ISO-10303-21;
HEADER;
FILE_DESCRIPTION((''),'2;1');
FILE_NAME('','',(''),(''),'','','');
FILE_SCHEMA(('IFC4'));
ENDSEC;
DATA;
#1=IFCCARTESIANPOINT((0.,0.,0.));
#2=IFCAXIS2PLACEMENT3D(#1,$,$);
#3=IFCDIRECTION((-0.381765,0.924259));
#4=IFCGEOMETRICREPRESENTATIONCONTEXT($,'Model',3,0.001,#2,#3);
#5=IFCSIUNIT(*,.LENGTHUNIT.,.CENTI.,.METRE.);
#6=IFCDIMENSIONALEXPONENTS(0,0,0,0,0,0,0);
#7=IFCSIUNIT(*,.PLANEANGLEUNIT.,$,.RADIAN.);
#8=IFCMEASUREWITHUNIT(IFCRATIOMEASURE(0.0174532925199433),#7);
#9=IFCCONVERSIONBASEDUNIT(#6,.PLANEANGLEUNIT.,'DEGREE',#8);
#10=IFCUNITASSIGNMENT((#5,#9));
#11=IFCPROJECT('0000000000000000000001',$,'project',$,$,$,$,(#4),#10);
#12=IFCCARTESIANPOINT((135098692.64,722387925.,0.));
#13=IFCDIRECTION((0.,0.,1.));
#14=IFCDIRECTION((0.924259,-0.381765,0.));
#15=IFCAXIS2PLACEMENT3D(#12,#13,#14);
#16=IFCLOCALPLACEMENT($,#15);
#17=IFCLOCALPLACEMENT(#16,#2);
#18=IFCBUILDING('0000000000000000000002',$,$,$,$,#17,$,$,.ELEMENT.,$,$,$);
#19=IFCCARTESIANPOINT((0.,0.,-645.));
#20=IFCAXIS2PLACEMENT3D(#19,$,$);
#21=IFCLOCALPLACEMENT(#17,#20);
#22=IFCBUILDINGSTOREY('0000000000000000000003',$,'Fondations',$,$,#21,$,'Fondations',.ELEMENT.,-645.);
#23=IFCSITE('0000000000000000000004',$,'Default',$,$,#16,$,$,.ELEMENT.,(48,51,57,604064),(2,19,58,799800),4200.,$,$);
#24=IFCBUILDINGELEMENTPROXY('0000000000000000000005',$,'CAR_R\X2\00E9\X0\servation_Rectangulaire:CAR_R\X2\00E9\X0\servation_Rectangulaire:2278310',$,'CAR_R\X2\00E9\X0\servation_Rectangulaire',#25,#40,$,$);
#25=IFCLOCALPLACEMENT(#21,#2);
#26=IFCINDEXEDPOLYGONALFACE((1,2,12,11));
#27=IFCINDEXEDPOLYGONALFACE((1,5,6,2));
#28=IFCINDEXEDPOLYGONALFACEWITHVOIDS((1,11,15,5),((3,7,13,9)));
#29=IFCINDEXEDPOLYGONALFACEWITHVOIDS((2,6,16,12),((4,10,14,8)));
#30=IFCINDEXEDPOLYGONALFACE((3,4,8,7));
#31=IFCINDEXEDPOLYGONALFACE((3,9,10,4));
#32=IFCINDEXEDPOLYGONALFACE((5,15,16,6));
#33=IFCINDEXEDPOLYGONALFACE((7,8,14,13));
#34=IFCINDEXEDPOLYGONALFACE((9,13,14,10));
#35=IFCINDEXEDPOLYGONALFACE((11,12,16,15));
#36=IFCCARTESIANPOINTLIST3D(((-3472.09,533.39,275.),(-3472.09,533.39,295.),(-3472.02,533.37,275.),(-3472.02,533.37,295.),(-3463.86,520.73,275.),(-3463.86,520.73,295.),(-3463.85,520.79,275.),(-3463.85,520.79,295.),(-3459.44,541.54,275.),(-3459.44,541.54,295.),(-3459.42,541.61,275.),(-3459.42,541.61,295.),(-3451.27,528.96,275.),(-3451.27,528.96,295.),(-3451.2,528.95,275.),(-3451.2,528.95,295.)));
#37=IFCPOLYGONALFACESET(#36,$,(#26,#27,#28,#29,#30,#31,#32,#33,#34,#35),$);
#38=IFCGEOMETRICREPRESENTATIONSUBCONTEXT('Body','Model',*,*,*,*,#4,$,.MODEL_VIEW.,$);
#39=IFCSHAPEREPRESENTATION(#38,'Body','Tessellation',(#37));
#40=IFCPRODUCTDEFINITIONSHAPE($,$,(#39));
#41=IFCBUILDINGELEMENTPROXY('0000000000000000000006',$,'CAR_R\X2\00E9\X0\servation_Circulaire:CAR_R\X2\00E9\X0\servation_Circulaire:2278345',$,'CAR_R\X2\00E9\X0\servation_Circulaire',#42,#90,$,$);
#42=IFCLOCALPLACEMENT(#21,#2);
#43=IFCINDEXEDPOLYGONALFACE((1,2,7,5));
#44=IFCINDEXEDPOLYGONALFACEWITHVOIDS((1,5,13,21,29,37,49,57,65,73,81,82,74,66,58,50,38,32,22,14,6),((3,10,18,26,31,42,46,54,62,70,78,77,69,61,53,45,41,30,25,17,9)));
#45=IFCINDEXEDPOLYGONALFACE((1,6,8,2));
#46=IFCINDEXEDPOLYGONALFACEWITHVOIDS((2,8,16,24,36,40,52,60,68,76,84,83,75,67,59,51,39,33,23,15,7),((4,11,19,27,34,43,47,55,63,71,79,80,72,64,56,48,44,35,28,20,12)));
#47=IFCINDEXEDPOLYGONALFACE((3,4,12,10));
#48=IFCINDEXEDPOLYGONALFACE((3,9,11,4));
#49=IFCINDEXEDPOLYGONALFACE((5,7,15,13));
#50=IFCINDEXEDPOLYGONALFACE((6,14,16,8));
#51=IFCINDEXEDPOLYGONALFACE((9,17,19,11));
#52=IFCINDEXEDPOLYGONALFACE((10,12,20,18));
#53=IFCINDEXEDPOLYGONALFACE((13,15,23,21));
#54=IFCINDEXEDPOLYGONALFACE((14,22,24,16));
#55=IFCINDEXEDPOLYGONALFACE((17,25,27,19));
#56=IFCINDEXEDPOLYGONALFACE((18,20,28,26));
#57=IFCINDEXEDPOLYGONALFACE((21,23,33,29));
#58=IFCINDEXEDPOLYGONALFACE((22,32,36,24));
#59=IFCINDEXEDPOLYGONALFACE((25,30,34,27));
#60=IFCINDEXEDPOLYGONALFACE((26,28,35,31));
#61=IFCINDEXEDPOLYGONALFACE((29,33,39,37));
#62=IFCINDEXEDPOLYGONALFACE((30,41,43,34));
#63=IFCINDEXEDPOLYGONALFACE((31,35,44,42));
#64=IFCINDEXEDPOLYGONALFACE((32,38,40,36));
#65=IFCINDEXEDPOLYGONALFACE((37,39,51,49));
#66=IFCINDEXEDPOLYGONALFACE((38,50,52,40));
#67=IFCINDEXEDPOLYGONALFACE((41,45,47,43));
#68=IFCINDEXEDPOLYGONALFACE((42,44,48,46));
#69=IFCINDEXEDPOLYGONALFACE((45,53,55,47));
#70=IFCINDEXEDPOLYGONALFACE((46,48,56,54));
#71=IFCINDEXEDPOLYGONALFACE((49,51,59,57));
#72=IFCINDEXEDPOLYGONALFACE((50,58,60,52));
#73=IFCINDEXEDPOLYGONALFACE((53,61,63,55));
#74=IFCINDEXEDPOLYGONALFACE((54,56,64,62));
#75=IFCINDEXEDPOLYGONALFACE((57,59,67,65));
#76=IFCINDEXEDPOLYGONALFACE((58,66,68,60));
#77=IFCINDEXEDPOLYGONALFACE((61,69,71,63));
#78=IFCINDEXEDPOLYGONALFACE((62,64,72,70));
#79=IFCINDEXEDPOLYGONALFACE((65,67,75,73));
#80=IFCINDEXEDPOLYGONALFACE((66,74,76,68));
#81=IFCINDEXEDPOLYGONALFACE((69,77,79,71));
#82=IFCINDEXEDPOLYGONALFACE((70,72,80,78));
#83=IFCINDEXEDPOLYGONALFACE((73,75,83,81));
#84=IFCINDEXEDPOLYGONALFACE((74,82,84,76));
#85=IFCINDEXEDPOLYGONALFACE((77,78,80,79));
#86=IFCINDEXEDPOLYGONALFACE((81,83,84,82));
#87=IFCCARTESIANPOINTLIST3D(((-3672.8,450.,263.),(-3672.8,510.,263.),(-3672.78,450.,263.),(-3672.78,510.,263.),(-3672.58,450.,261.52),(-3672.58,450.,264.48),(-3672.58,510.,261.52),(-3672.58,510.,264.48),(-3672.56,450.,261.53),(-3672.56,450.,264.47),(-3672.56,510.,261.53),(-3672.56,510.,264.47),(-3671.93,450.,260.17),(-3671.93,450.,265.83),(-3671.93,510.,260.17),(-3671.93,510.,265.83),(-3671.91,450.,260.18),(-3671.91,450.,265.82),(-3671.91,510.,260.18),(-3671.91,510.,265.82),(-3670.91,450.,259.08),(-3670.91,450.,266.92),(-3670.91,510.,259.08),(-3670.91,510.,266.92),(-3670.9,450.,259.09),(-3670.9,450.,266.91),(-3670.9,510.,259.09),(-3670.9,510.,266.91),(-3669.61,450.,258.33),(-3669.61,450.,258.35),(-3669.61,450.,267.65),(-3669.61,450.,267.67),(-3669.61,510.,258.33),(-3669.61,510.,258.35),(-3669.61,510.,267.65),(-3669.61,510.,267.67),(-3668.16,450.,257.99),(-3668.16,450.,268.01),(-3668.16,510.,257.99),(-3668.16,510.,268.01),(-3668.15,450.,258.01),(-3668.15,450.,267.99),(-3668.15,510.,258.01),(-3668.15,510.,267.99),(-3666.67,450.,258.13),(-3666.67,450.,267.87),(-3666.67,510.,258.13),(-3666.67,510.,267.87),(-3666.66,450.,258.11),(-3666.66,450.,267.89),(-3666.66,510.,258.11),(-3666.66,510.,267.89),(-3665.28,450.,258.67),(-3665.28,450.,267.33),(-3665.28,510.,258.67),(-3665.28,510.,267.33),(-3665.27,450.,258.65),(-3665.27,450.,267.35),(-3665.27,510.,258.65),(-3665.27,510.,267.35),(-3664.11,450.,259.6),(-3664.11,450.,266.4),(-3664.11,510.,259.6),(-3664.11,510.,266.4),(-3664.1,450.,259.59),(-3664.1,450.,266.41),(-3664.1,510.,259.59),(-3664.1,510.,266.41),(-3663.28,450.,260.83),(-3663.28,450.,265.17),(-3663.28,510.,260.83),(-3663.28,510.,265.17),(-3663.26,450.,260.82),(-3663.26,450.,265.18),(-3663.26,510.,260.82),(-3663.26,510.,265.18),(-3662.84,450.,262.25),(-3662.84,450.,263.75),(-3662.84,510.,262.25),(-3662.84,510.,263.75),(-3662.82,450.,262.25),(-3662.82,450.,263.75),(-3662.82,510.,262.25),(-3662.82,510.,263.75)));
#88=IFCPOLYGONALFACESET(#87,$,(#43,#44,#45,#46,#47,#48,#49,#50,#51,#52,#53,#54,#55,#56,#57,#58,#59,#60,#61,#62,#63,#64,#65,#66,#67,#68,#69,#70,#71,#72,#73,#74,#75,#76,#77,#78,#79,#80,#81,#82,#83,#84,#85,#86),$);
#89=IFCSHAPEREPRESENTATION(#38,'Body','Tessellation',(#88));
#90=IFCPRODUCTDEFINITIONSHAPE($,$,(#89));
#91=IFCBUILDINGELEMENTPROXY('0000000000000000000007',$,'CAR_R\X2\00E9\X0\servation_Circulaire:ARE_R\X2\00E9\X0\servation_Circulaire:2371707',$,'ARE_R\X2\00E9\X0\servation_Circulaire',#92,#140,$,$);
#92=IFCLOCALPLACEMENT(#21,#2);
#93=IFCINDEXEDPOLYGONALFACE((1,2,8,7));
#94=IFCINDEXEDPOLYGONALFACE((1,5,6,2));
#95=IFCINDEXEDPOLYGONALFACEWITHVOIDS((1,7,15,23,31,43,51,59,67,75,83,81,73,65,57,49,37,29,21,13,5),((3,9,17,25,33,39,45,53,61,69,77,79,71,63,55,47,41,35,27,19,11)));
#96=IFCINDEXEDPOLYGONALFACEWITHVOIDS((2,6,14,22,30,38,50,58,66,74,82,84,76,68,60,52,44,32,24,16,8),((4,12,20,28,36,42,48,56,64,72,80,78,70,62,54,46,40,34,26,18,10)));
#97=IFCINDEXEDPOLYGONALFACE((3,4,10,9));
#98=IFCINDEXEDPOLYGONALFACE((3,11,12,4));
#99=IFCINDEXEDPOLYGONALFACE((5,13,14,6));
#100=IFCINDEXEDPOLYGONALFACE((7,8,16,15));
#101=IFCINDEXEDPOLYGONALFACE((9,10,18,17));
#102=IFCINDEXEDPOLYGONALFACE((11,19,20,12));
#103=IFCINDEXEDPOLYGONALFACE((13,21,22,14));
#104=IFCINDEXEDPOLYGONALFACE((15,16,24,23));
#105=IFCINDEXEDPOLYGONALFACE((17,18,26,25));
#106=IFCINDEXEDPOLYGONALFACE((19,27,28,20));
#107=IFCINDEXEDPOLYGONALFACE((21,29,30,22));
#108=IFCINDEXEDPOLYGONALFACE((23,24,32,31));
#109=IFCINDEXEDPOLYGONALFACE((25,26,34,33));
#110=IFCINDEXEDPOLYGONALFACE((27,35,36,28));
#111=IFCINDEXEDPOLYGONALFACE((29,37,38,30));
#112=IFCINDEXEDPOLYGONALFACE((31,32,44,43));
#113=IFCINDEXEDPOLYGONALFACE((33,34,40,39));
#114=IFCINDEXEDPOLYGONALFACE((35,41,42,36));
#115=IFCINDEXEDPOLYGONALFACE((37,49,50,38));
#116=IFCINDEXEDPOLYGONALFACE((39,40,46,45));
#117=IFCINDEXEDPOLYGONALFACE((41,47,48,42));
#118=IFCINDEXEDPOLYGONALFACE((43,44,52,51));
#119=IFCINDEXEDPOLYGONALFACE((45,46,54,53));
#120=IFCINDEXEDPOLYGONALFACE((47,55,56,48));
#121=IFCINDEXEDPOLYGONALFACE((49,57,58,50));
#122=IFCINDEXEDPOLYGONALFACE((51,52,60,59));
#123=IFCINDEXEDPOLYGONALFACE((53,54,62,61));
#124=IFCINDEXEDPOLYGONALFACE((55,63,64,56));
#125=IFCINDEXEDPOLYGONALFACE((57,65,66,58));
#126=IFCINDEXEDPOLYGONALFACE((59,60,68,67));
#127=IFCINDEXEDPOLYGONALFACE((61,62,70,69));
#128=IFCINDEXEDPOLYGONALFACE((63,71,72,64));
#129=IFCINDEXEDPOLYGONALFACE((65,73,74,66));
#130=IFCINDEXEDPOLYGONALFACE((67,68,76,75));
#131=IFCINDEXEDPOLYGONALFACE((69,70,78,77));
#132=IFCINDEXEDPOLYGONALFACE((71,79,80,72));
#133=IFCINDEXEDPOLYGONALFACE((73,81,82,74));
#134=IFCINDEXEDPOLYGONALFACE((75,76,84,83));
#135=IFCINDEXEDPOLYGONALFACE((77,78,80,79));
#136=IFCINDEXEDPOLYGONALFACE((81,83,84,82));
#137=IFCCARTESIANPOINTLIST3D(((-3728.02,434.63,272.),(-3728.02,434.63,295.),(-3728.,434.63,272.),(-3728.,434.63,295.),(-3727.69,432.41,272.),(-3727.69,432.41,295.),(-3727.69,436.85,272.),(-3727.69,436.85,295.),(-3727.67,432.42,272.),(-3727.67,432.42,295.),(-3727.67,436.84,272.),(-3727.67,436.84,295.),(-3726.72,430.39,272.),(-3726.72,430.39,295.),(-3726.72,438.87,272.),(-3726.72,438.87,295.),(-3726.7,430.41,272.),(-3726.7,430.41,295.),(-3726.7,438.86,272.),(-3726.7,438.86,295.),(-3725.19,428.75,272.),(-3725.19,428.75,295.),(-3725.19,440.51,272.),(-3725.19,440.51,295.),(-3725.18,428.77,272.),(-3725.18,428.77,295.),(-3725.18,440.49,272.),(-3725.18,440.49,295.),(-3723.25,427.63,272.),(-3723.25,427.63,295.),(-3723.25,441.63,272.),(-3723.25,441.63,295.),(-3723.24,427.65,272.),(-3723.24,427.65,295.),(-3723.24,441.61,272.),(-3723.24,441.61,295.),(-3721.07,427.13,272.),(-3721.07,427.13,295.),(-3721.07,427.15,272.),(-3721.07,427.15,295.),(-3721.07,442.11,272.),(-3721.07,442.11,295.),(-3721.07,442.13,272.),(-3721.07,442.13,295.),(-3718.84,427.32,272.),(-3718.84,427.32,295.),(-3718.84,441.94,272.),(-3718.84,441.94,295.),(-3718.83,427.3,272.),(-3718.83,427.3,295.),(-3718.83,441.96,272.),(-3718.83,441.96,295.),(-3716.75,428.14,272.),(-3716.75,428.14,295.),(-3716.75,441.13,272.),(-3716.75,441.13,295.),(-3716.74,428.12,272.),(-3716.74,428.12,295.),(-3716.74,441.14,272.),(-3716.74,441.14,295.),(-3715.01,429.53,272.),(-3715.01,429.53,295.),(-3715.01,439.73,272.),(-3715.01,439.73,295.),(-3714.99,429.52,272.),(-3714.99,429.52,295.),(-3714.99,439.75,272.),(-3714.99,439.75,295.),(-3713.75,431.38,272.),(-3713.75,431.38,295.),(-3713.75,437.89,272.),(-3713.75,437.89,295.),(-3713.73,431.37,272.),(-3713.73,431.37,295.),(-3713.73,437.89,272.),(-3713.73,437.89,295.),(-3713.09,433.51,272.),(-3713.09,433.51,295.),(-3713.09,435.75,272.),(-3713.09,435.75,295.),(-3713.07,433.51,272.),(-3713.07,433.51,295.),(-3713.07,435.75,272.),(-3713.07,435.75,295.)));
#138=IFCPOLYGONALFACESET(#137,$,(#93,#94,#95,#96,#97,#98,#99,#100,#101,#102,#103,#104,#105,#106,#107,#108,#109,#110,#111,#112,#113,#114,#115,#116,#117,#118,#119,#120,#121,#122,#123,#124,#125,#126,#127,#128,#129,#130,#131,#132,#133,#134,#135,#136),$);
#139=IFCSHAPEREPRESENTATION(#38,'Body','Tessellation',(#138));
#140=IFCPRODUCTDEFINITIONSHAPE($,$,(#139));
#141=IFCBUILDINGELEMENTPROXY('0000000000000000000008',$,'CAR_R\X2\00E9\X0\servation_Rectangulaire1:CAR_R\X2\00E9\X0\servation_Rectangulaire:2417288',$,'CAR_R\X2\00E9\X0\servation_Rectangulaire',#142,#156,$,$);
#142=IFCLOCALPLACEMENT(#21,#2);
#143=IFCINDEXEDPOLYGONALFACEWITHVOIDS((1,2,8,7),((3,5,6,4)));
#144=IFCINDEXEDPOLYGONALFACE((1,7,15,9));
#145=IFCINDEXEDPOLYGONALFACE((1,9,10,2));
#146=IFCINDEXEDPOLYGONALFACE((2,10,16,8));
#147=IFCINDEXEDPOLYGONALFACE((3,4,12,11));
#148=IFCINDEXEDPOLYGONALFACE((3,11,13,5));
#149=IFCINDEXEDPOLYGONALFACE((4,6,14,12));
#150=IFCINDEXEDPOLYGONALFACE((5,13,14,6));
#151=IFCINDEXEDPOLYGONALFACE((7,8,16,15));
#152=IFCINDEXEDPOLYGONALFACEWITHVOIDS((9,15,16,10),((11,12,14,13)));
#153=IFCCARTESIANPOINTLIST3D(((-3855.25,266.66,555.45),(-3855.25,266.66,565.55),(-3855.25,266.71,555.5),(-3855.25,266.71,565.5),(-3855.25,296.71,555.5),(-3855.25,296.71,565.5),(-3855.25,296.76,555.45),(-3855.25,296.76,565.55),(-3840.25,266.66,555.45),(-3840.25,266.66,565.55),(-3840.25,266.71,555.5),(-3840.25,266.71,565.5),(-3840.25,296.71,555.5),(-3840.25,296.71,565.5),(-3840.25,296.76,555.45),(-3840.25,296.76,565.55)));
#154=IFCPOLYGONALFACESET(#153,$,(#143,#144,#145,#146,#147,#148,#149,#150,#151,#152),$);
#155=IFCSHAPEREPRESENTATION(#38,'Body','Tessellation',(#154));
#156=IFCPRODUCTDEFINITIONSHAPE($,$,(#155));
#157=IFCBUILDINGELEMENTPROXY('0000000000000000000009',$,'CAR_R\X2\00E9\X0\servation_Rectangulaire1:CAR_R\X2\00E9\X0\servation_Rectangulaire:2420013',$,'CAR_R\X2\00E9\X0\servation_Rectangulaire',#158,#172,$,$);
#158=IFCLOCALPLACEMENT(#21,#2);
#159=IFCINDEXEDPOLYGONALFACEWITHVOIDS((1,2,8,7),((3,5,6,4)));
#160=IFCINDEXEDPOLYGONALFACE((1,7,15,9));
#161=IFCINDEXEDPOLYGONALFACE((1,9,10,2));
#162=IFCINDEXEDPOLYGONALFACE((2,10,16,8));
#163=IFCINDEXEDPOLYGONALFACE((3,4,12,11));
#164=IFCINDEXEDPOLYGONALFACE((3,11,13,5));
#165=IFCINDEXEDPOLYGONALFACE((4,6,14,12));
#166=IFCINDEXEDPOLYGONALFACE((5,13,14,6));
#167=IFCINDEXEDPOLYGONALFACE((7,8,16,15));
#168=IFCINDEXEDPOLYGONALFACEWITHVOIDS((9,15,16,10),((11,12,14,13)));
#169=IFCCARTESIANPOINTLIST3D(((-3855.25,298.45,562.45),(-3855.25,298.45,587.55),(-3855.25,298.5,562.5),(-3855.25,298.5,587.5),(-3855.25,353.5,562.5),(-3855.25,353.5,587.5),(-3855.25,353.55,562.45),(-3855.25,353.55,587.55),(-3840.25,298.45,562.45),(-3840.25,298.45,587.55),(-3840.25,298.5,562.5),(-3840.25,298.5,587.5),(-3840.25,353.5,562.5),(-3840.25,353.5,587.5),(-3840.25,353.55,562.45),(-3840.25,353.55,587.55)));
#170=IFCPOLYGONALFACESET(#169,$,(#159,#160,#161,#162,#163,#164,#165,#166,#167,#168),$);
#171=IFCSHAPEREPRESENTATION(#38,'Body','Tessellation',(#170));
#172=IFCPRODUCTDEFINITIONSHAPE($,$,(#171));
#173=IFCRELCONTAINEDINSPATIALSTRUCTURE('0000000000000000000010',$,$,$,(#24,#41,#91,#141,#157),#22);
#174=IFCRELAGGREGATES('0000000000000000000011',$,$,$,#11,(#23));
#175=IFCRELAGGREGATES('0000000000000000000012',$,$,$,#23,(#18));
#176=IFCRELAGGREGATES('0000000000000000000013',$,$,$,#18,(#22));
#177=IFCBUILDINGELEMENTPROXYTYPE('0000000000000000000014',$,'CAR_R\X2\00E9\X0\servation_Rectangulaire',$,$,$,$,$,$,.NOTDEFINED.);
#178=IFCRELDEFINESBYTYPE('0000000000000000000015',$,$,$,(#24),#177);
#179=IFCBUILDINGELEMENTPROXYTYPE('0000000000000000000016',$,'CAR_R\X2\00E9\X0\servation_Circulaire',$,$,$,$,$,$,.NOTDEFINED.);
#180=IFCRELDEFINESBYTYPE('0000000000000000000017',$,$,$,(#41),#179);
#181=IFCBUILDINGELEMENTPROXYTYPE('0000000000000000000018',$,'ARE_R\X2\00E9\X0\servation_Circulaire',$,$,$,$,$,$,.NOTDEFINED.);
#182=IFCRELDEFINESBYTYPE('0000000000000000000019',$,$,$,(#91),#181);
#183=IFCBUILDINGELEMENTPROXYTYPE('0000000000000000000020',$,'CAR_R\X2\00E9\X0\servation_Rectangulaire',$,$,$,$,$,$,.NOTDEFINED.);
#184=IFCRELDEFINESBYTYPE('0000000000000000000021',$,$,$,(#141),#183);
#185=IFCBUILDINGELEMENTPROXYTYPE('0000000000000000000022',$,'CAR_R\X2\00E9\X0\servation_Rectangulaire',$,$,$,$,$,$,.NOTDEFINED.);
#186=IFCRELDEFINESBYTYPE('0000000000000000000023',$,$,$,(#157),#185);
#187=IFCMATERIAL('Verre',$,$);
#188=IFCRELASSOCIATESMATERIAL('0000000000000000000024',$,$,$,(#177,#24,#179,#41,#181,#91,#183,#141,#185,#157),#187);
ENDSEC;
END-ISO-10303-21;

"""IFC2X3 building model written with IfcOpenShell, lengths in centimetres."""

from ifc_helpers import new_model, entity, si_unit, converted_unit, direction, frame, frame_2d, origin, place, context, subcontext, project, spatial, polyline, hollow_circle, outline, extrude, source, transform, mapped, material, type_object, type_shapes, element, save


model = new_model("IFC2X3")

# Units and contexts
model_context = context("Model", 3, precision=0.001, world=origin(), true_north=direction((-0.381765, 0.924259)))
body_context = subcontext(model_context, "Body", "Model", "MODEL_VIEW")
ifc_project = project(units=[si_unit("LENGTHUNIT", "METRE", prefix="CENTI"), converted_unit("PLANEANGLEUNIT", "DEGREE", entity("IfcRatioMeasure", 0.0174532925199433), si_unit("PLANEANGLEUNIT", "RADIAN"), dimensions=[0, 0, 0, 0, 0, 0, 0])], contexts=[model_context])

# Site, building, storey
site_placement = place(None, frame((135098692.64, 722387925.0, 0.0), z_axis=(0.0, 0.0, 1.0), x_axis=(0.924259, -0.381765, 0.0)))
site = spatial("IfcSite", under=ifc_project, at=site_placement, Name="Default", CompositionType="ELEMENT", RefLatitude=(48, 51, 57, 604064), RefLongitude=(2, 19, 58, 799800), RefElevation=4200.0)
building_placement = place(site_placement, origin())
building = spatial("IfcBuilding", under=site, at=building_placement, CompositionType="ELEMENT")
storey_placement = place(building_placement, frame((0.0, 0.0, -645.0)))
storey = spatial("IfcBuildingStorey", under=building, at=storey_placement, Name="Fondations", LongName="Fondations", CompositionType="ELEMENT", Elevation=-645.0)

# Building element proxies
ifc_material_1 = material(Name="Verre")
building_element_proxy_type_1 = type_object("IfcBuildingElementProxyType", Name="CAR_Réservation_Rectangulaire", PredefinedType="NOTDEFINED", material=ifc_material_1)
shared_shape_1 = source(origin(), body_context, "Body", "SweptSolid", [
    extrude(outline(polyline([(-7.55, -7.55), (7.55, -7.55), (7.55, 7.55), (-7.55, 7.55), (-7.55, -7.55)]), holes=[polyline([(7.5, -7.5), (-7.5, -7.5), (-7.5, 7.5), (7.5, 7.5), (7.5, -7.5)])]), frame((0.0, 0.0, -20.0), z_axis=(0.0, 0.0, 1.0), x_axis=(-1.0, 0.0, 0.0)), (0.0, 0.0, 1.0), 20.0),
])
type_shapes(building_element_proxy_type_1, [shared_shape_1])
proxy_1_placement = place(storey_placement, frame((-3461.64, 531.17, 295.0), z_axis=(0.0, 0.0, 1.0), x_axis=(-0.544639, 0.838671, 0.0)))
element("IfcBuildingElementProxy", 1, at=proxy_1_placement, inside=storey, type_object=building_element_proxy_type_1, material=ifc_material_1, Name="CAR_Réservation_Rectangulaire:CAR_Réservation_Rectangulaire:2278310", ObjectType="CAR_Réservation_Rectangulaire", context=body_context, shape_type="MappedRepresentation", body=[
    mapped(shared_shape_1, transform((0.0, 0.0, 0.0), scale=1.0)),
])
building_element_proxy_type_2 = type_object("IfcBuildingElementProxyType", Name="CAR_Réservation_Circulaire", PredefinedType="NOTDEFINED", material=ifc_material_1)
shared_shape_2 = source(origin(), body_context, "Body", "SweptSolid", [
    extrude(hollow_circle(Radius=5.02, WallThickness=0.02, at=frame_2d((0.0, 0.0), x_axis=(1.0, 0.0))), frame((0.0, 0.0, -60.0)), (0.0, 0.0, 1.0), 60.0),
])
type_shapes(building_element_proxy_type_2, [shared_shape_2])
proxy_2_placement = place(storey_placement, frame((-3667.78, 450.0, 263.0), z_axis=(0.0, -1.0, 0.0), x_axis=(-1.0, 0.0, 0.0)))
element("IfcBuildingElementProxy", 2, at=proxy_2_placement, inside=storey, type_object=building_element_proxy_type_2, material=ifc_material_1, Name="CAR_Réservation_Circulaire:CAR_Réservation_Circulaire:2278345", ObjectType="CAR_Réservation_Circulaire", context=body_context, shape_type="MappedRepresentation", body=[
    mapped(shared_shape_2, transform((0.0, 0.0, 0.0), scale=1.0)),
])
building_element_proxy_type_3 = type_object("IfcBuildingElementProxyType", Name="ARE_Réservation_Circulaire", PredefinedType="NOTDEFINED", material=ifc_material_1)
shared_shape_3 = source(origin(), body_context, "Body", "SweptSolid", [
    extrude(hollow_circle(Radius=7.52, WallThickness=0.02, at=frame_2d((0.0, 0.0), x_axis=(1.0, 0.0))), frame((0.0, 0.0, -23.0)), (0.0, 0.0, 1.0), 23.0),
])
type_shapes(building_element_proxy_type_3, [shared_shape_3])
proxy_3_placement = place(storey_placement, frame((-3720.5, 434.63, 295.0), z_axis=(0.0, 0.0, 1.0), x_axis=(-1.0, 0.0, 0.0)))
element("IfcBuildingElementProxy", 3, at=proxy_3_placement, inside=storey, type_object=building_element_proxy_type_3, material=ifc_material_1, Name="CAR_Réservation_Circulaire:ARE_Réservation_Circulaire:2371707", ObjectType="ARE_Réservation_Circulaire", context=body_context, shape_type="MappedRepresentation", body=[
    mapped(shared_shape_3, transform((0.0, 0.0, 0.0), scale=1.0)),
])
building_element_proxy_type_4 = type_object("IfcBuildingElementProxyType", Name="CAR_Réservation_Rectangulaire", PredefinedType="NOTDEFINED", material=ifc_material_1)
shared_shape_4 = source(origin(), body_context, "Body", "SweptSolid", [
    extrude(outline(polyline([(-15.05, -5.05), (15.05, -5.05), (15.05, 5.05), (-15.05, 5.05), (-15.05, -5.05)]), holes=[polyline([(15.0, -5.0), (-15.0, -5.0), (-15.0, 5.0), (15.0, 5.0), (15.0, -5.0)])]), frame((0.0, 0.0, -15.0), z_axis=(0.0, 0.0, 1.0), x_axis=(-1.0, 0.0, 0.0)), (0.0, 0.0, 1.0), 15.0),
])
type_shapes(building_element_proxy_type_4, [shared_shape_4])
proxy_4_placement = place(storey_placement, frame((-3855.25, 281.71, 560.5), z_axis=(-1.0, 0.0, 0.0), x_axis=(0.0, -1.0, 0.0)))
element("IfcBuildingElementProxy", 4, at=proxy_4_placement, inside=storey, type_object=building_element_proxy_type_4, material=ifc_material_1, Name="CAR_Réservation_Rectangulaire1:CAR_Réservation_Rectangulaire:2417288", ObjectType="CAR_Réservation_Rectangulaire", context=body_context, shape_type="MappedRepresentation", body=[
    mapped(shared_shape_4, transform((0.0, 0.0, 0.0), scale=1.0)),
])
building_element_proxy_type_5 = type_object("IfcBuildingElementProxyType", Name="CAR_Réservation_Rectangulaire", PredefinedType="NOTDEFINED", material=ifc_material_1)
shared_shape_5 = source(origin(), body_context, "Body", "SweptSolid", [
    extrude(outline(polyline([(-27.55, -12.55), (27.55, -12.55), (27.55, 12.55), (-27.55, 12.55), (-27.55, -12.55)]), holes=[polyline([(27.5, -12.5), (-27.5, -12.5), (-27.5, 12.5), (27.5, 12.5), (27.5, -12.5)])]), frame((0.0, 0.0, -15.0), z_axis=(0.0, 0.0, 1.0), x_axis=(-1.0, 0.0, 0.0)), (0.0, 0.0, 1.0), 15.0),
])
type_shapes(building_element_proxy_type_5, [shared_shape_5])
proxy_5_placement = place(storey_placement, frame((-3840.25, 326.0, 575.0), z_axis=(1.0, 0.0, 0.0), x_axis=(0.0, 1.0, 0.0)))
element("IfcBuildingElementProxy", 5, at=proxy_5_placement, inside=storey, type_object=building_element_proxy_type_5, material=ifc_material_1, Name="CAR_Réservation_Rectangulaire1:CAR_Réservation_Rectangulaire:2420013", ObjectType="CAR_Réservation_Rectangulaire", context=body_context, shape_type="MappedRepresentation", body=[
    mapped(shared_shape_5, transform((0.0, 0.0, 0.0), scale=1.0)),
])

save(model, "model.ifc")
